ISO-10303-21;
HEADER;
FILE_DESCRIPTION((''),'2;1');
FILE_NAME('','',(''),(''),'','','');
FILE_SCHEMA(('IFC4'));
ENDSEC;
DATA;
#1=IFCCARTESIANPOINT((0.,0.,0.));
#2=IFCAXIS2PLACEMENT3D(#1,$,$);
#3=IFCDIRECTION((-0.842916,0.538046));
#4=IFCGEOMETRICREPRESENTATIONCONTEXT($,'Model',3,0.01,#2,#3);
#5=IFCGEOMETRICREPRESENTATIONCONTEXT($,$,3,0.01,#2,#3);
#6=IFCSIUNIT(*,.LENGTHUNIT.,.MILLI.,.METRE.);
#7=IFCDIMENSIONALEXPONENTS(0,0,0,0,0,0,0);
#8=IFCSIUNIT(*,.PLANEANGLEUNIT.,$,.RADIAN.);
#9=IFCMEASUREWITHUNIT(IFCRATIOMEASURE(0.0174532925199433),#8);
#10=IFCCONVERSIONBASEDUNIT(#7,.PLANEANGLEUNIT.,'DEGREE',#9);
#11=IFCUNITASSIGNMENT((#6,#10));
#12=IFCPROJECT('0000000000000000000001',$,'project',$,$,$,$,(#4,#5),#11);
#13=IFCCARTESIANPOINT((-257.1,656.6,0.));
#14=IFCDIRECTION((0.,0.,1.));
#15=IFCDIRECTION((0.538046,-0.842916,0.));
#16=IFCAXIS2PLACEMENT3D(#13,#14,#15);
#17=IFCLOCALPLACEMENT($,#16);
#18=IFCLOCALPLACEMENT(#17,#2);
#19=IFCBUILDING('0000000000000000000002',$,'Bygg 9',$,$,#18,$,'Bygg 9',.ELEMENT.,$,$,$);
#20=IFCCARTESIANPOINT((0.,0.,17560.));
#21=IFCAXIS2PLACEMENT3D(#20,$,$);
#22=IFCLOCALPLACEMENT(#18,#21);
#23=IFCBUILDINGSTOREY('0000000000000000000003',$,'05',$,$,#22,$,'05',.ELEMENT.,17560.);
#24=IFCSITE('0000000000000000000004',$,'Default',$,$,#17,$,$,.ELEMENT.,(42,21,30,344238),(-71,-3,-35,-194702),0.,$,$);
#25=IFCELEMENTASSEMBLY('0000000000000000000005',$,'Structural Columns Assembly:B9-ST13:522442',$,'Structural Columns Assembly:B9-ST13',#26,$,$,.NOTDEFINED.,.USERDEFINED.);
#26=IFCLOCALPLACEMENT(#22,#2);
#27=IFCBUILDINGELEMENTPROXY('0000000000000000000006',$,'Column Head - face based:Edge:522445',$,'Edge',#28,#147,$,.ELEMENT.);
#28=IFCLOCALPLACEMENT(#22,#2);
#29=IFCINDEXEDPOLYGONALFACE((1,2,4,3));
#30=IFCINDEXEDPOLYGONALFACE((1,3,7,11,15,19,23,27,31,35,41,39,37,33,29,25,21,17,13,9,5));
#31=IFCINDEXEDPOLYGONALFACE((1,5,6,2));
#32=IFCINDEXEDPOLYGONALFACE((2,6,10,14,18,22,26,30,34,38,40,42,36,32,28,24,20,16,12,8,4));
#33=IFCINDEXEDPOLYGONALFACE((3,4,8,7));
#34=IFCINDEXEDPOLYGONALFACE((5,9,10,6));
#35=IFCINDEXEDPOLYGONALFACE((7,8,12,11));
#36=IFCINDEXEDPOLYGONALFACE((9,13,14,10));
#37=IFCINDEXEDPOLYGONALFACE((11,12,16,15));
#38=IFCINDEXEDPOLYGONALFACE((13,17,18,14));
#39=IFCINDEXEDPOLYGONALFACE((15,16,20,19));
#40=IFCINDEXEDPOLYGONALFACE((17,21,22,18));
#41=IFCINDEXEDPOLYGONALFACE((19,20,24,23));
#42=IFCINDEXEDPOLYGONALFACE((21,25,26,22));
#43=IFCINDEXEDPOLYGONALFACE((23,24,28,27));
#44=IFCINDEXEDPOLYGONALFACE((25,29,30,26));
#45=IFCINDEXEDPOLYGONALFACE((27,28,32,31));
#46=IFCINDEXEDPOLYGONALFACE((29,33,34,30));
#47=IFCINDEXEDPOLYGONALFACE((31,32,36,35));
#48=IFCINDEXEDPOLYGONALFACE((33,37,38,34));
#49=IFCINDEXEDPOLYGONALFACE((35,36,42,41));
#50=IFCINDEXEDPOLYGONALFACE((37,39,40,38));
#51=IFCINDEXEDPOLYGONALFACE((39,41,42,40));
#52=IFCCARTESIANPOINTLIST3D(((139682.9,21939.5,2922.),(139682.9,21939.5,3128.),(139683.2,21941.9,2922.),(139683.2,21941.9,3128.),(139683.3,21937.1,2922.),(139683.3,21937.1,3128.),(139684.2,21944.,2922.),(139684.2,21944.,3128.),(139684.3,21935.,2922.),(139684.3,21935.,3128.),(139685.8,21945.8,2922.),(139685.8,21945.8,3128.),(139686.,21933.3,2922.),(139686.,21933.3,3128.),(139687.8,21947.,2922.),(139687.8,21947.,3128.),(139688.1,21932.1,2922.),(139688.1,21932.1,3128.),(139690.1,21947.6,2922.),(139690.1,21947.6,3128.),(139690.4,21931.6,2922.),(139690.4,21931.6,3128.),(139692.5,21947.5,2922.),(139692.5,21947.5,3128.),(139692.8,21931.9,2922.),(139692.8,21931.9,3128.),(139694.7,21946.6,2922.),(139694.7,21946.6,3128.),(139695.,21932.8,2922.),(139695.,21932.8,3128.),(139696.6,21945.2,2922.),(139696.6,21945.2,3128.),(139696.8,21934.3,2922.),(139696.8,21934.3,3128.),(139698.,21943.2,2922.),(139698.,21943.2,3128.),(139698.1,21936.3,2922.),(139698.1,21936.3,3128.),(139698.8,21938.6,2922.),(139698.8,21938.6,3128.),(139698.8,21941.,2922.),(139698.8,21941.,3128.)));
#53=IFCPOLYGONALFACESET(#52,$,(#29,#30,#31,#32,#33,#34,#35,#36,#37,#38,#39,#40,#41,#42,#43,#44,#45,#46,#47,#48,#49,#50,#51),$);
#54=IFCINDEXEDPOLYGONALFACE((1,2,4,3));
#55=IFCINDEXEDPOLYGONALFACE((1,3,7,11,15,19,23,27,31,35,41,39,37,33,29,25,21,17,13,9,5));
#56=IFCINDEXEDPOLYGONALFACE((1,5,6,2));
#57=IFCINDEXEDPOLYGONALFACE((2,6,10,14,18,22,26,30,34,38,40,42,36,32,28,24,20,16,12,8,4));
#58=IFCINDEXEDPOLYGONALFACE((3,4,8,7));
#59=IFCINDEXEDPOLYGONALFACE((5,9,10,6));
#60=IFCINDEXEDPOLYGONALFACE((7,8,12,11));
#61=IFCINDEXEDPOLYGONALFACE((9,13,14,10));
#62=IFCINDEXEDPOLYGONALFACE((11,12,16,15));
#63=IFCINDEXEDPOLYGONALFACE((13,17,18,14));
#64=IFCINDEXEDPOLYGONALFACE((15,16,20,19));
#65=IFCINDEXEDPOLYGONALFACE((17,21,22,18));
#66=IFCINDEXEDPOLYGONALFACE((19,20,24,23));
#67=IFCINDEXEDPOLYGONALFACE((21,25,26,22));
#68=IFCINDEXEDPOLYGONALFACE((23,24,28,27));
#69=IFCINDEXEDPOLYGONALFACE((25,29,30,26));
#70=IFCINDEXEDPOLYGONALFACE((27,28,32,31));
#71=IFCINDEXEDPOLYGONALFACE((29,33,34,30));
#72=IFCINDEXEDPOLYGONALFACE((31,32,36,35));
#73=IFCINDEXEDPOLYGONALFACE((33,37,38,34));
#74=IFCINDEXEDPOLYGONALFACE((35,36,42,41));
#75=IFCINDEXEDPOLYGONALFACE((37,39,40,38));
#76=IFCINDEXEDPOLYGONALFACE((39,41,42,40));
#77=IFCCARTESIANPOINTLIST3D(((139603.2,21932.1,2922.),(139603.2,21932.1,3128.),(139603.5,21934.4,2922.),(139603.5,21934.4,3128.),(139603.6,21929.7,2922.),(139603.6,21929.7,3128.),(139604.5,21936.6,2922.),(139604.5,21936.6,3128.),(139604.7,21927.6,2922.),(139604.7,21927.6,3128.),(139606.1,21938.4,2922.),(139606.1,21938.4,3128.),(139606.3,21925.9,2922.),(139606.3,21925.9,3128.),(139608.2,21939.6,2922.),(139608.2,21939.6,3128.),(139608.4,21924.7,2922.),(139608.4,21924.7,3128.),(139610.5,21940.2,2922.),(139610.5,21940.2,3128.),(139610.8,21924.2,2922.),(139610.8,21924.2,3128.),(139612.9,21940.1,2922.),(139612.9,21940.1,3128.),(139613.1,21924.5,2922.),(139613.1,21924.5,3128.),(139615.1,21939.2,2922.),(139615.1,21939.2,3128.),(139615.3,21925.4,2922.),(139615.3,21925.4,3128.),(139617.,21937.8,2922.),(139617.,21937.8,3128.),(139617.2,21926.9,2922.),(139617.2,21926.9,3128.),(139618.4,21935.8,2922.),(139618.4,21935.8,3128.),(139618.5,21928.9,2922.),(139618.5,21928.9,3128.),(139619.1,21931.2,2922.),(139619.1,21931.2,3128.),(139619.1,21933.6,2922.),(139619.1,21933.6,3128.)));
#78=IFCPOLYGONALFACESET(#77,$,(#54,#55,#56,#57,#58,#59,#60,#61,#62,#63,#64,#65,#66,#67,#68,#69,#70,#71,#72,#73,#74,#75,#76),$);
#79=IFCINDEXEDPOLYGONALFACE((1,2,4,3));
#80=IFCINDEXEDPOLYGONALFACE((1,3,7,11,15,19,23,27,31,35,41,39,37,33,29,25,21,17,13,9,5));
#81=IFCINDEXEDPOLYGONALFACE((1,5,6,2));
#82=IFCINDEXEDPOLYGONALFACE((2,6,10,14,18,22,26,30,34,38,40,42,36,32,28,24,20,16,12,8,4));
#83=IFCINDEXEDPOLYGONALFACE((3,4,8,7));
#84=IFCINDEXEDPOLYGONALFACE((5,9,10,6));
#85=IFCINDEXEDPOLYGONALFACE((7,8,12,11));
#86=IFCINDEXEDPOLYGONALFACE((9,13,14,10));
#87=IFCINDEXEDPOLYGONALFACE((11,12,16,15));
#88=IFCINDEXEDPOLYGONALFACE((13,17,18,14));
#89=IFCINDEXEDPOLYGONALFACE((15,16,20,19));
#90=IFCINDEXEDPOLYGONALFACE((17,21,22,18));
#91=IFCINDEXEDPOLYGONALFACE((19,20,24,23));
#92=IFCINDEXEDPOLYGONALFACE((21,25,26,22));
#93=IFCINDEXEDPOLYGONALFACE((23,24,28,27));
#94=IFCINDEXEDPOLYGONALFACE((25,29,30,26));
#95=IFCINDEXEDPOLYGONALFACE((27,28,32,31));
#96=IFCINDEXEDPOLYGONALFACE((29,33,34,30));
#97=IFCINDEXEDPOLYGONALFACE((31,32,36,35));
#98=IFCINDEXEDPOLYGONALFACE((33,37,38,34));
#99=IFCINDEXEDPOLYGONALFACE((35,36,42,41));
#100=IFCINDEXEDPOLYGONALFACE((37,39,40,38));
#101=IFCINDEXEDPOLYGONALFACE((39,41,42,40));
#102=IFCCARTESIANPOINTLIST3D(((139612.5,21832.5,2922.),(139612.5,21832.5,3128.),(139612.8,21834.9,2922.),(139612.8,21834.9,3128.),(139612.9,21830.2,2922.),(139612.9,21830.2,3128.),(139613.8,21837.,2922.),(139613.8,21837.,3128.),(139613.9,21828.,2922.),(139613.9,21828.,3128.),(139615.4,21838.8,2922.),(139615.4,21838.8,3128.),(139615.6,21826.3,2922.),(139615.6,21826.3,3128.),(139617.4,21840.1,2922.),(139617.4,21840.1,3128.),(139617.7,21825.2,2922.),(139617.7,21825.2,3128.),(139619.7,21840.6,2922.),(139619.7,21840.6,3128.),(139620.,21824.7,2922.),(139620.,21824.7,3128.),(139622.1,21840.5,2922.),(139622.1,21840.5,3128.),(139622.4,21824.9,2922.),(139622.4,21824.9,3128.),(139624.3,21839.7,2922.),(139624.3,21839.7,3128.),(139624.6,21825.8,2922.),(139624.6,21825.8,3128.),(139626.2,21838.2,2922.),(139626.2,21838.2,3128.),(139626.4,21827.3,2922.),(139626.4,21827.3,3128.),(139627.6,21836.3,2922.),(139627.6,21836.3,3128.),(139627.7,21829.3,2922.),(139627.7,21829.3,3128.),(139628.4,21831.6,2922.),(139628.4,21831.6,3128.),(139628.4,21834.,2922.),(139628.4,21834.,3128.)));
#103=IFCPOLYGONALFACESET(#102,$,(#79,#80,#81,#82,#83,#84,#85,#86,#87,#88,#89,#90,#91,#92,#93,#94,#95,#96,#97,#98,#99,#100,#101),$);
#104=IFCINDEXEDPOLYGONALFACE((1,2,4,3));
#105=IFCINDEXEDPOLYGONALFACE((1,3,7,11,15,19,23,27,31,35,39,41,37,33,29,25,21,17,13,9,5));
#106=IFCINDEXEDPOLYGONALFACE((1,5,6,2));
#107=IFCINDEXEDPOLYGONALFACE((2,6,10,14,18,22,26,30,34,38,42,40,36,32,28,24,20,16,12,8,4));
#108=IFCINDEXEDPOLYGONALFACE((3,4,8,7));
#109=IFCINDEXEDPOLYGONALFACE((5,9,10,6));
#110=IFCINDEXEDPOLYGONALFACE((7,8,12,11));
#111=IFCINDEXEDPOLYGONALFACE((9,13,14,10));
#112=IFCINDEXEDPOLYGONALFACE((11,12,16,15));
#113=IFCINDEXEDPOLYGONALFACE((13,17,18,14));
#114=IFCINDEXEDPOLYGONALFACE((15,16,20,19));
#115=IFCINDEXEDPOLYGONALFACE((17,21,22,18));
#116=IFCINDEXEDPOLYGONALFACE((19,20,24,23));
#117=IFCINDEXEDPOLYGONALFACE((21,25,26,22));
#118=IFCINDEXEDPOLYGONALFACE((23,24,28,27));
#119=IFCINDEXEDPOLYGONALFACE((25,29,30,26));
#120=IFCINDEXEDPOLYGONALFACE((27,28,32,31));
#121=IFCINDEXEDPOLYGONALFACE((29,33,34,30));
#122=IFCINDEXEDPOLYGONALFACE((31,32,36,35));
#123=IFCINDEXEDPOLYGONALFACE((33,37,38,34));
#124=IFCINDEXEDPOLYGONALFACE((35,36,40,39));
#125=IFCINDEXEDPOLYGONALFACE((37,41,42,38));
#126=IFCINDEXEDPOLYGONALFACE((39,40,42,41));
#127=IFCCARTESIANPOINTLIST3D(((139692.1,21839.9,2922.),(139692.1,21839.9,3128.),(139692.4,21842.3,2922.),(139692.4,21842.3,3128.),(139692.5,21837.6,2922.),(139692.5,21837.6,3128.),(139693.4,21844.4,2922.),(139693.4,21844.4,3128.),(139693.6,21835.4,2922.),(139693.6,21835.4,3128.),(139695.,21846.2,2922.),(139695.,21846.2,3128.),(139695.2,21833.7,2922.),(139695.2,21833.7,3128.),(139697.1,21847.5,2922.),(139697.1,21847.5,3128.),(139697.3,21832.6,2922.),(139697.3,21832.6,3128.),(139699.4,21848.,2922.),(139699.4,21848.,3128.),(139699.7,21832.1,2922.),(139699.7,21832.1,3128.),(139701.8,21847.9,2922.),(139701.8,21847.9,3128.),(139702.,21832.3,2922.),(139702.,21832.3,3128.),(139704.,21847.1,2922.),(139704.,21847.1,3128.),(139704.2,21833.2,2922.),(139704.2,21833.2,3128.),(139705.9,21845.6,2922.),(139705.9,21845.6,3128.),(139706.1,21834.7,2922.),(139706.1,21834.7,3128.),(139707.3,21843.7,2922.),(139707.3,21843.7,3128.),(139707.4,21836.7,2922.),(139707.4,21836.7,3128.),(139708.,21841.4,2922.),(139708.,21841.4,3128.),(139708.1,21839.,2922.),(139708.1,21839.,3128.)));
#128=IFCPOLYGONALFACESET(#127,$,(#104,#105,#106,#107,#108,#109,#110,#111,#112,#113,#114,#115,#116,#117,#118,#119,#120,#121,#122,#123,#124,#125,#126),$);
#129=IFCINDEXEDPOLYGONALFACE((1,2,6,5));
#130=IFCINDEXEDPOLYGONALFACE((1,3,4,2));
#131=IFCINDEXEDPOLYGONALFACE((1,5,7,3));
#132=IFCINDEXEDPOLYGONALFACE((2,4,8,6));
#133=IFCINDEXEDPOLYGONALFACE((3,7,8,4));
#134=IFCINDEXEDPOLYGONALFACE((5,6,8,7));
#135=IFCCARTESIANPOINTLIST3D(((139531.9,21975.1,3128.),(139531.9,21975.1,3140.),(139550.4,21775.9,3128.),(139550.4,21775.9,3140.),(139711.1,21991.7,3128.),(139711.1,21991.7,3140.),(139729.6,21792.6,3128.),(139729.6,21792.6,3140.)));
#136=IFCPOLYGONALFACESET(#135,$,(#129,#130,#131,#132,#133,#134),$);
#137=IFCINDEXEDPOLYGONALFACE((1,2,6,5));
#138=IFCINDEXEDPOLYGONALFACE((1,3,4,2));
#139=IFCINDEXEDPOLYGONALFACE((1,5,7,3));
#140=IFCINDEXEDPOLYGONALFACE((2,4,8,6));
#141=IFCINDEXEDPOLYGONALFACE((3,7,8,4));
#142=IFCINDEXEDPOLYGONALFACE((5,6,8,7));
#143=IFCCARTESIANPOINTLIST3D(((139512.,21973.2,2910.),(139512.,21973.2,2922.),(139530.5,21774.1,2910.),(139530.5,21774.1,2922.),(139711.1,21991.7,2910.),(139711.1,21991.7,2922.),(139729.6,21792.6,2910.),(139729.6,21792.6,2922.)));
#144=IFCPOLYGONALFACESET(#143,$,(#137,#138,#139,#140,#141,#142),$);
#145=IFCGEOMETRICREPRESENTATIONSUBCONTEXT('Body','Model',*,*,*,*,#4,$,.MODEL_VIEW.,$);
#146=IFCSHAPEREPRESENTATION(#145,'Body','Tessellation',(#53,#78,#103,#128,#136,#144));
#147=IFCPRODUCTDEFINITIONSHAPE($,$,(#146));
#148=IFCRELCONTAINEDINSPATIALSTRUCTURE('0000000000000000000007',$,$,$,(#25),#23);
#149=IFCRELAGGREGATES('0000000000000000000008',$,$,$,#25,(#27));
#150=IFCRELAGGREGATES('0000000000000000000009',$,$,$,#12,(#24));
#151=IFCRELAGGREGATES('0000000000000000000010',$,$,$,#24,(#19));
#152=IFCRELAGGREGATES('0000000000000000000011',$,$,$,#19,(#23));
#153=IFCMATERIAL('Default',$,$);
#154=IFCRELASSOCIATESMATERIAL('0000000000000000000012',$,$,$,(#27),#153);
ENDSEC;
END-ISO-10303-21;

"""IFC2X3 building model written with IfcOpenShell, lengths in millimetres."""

from ifc_helpers import new_model, entity, si_unit, converted_unit, direction, frame, frame_2d, origin, origin_2d_with_axis, place, context, subcontext, project, spatial, rectangle, circle, extrude, source, transform, mapped, material, element, aggregate, save


model = new_model("IFC2X3")

# Units and contexts
model_context = context("Model", 3, precision=0.01, world=origin(), true_north=direction((-0.842916, 0.538046)))
context_of_model = context(None, 3, precision=0.01, world=origin(), true_north=direction((-0.842916, 0.538046)))
body_context = subcontext(model_context, "Body", "Model", "MODEL_VIEW")
ifc_project = project(units=[si_unit("LENGTHUNIT", "METRE", prefix="MILLI"), converted_unit("PLANEANGLEUNIT", "DEGREE", entity("IfcRatioMeasure", 0.0174532925199433), si_unit("PLANEANGLEUNIT", "RADIAN"), dimensions=[0, 0, 0, 0, 0, 0, 0])], contexts=[model_context, context_of_model])

# Site, building, storey
site_placement = place(None, frame((-257.1, 656.6, 0.0), z_axis=(0.0, 0.0, 1.0), x_axis=(0.538046, -0.842916, 0.0)))
site = spatial("IfcSite", under=ifc_project, at=site_placement, Name="Default", CompositionType="ELEMENT", RefLatitude=(42, 21, 30, 344238), RefLongitude=(-71, -3, -35, -194702), RefElevation=0.0)
building_placement = place(site_placement, origin())
building = spatial("IfcBuilding", under=site, at=building_placement, Name="Bygg 9", LongName="Bygg 9", CompositionType="ELEMENT")
storey_placement = place(building_placement, frame((0.0, 0.0, 17560.0)))
storey = spatial("IfcBuildingStorey", under=building, at=storey_placement, Name="05", LongName="05", CompositionType="ELEMENT", Elevation=17560.0)

# Shared definitions
ifc_material_1 = material(Name="Default")

# Element assembly, building element proxy
shared_shape_1 = source(origin(), body_context, "Body", "SweptSolid", [
    extrude(circle(Radius=8.0, at=frame_2d((0.0, 0.0), x_axis=(1.0, 0.0))), frame((50.0, -135.0, 12.0)), (0.0, 0.0, 1.0), 206.0),
    extrude(circle(Radius=8.0, at=frame_2d((0.0, 0.0), x_axis=(1.0, 0.0))), frame((50.0, -55.0, 12.0)), (0.0, 0.0, 1.0), 206.0),
    extrude(circle(Radius=8.0, at=frame_2d((0.0, 0.0), x_axis=(1.0, 0.0))), frame((-50.0, -55.0, 12.0)), (0.0, 0.0, 1.0), 206.0),
    extrude(circle(Radius=8.0, at=frame_2d((0.0, 0.0), x_axis=(1.0, 0.0))), frame((-50.0, -135.0, 12.0)), (0.0, 0.0, 1.0), 206.0),
    extrude(rectangle(XDim=200.0, YDim=180.0, at=origin_2d_with_axis()), frame((0.0, -70.0, 218.0), z_axis=(0.0, 0.0, 1.0), x_axis=(-1.0, 0.0, 0.0)), (0.0, 0.0, 1.0), 12.0),
    extrude(rectangle(XDim=200.0, YDim=200.0, at=origin_2d_with_axis()), frame((0.0, -60.0, 0.0), z_axis=(0.0, 0.0, 1.0), x_axis=(0.0, 1.0, 0.0)), (0.0, 0.0, 1.0), 12.0),
])
assembly_1_placement = place(storey_placement, origin())
assembly_1 = element("IfcElementAssembly", 1, at=assembly_1_placement, inside=storey, Name="Structural Columns Assembly:B9-ST13:522442", ObjectType="Structural Columns Assembly:B9-ST13", AssemblyPlace="NOTDEFINED", PredefinedType="USERDEFINED")
proxy_1_placement = place(assembly_1_placement, frame((139561.1, 21877.4, 2910.0), z_axis=(0.0, 0.0, 1.0), x_axis=(-0.092535, 0.995709, 0.0)))
proxy_1 = element("IfcBuildingElementProxy", 2, at=proxy_1_placement, material=ifc_material_1, Name="Column Head - face based:Edge:522445", ObjectType="Edge", CompositionType="ELEMENT", context=body_context, shape_type="MappedRepresentation", body=[
    mapped(shared_shape_1, transform((0.0, 0.0, 0.0), scale=1.0)),
])
aggregate(assembly_1, [proxy_1])

save(model, "model.ifc")
